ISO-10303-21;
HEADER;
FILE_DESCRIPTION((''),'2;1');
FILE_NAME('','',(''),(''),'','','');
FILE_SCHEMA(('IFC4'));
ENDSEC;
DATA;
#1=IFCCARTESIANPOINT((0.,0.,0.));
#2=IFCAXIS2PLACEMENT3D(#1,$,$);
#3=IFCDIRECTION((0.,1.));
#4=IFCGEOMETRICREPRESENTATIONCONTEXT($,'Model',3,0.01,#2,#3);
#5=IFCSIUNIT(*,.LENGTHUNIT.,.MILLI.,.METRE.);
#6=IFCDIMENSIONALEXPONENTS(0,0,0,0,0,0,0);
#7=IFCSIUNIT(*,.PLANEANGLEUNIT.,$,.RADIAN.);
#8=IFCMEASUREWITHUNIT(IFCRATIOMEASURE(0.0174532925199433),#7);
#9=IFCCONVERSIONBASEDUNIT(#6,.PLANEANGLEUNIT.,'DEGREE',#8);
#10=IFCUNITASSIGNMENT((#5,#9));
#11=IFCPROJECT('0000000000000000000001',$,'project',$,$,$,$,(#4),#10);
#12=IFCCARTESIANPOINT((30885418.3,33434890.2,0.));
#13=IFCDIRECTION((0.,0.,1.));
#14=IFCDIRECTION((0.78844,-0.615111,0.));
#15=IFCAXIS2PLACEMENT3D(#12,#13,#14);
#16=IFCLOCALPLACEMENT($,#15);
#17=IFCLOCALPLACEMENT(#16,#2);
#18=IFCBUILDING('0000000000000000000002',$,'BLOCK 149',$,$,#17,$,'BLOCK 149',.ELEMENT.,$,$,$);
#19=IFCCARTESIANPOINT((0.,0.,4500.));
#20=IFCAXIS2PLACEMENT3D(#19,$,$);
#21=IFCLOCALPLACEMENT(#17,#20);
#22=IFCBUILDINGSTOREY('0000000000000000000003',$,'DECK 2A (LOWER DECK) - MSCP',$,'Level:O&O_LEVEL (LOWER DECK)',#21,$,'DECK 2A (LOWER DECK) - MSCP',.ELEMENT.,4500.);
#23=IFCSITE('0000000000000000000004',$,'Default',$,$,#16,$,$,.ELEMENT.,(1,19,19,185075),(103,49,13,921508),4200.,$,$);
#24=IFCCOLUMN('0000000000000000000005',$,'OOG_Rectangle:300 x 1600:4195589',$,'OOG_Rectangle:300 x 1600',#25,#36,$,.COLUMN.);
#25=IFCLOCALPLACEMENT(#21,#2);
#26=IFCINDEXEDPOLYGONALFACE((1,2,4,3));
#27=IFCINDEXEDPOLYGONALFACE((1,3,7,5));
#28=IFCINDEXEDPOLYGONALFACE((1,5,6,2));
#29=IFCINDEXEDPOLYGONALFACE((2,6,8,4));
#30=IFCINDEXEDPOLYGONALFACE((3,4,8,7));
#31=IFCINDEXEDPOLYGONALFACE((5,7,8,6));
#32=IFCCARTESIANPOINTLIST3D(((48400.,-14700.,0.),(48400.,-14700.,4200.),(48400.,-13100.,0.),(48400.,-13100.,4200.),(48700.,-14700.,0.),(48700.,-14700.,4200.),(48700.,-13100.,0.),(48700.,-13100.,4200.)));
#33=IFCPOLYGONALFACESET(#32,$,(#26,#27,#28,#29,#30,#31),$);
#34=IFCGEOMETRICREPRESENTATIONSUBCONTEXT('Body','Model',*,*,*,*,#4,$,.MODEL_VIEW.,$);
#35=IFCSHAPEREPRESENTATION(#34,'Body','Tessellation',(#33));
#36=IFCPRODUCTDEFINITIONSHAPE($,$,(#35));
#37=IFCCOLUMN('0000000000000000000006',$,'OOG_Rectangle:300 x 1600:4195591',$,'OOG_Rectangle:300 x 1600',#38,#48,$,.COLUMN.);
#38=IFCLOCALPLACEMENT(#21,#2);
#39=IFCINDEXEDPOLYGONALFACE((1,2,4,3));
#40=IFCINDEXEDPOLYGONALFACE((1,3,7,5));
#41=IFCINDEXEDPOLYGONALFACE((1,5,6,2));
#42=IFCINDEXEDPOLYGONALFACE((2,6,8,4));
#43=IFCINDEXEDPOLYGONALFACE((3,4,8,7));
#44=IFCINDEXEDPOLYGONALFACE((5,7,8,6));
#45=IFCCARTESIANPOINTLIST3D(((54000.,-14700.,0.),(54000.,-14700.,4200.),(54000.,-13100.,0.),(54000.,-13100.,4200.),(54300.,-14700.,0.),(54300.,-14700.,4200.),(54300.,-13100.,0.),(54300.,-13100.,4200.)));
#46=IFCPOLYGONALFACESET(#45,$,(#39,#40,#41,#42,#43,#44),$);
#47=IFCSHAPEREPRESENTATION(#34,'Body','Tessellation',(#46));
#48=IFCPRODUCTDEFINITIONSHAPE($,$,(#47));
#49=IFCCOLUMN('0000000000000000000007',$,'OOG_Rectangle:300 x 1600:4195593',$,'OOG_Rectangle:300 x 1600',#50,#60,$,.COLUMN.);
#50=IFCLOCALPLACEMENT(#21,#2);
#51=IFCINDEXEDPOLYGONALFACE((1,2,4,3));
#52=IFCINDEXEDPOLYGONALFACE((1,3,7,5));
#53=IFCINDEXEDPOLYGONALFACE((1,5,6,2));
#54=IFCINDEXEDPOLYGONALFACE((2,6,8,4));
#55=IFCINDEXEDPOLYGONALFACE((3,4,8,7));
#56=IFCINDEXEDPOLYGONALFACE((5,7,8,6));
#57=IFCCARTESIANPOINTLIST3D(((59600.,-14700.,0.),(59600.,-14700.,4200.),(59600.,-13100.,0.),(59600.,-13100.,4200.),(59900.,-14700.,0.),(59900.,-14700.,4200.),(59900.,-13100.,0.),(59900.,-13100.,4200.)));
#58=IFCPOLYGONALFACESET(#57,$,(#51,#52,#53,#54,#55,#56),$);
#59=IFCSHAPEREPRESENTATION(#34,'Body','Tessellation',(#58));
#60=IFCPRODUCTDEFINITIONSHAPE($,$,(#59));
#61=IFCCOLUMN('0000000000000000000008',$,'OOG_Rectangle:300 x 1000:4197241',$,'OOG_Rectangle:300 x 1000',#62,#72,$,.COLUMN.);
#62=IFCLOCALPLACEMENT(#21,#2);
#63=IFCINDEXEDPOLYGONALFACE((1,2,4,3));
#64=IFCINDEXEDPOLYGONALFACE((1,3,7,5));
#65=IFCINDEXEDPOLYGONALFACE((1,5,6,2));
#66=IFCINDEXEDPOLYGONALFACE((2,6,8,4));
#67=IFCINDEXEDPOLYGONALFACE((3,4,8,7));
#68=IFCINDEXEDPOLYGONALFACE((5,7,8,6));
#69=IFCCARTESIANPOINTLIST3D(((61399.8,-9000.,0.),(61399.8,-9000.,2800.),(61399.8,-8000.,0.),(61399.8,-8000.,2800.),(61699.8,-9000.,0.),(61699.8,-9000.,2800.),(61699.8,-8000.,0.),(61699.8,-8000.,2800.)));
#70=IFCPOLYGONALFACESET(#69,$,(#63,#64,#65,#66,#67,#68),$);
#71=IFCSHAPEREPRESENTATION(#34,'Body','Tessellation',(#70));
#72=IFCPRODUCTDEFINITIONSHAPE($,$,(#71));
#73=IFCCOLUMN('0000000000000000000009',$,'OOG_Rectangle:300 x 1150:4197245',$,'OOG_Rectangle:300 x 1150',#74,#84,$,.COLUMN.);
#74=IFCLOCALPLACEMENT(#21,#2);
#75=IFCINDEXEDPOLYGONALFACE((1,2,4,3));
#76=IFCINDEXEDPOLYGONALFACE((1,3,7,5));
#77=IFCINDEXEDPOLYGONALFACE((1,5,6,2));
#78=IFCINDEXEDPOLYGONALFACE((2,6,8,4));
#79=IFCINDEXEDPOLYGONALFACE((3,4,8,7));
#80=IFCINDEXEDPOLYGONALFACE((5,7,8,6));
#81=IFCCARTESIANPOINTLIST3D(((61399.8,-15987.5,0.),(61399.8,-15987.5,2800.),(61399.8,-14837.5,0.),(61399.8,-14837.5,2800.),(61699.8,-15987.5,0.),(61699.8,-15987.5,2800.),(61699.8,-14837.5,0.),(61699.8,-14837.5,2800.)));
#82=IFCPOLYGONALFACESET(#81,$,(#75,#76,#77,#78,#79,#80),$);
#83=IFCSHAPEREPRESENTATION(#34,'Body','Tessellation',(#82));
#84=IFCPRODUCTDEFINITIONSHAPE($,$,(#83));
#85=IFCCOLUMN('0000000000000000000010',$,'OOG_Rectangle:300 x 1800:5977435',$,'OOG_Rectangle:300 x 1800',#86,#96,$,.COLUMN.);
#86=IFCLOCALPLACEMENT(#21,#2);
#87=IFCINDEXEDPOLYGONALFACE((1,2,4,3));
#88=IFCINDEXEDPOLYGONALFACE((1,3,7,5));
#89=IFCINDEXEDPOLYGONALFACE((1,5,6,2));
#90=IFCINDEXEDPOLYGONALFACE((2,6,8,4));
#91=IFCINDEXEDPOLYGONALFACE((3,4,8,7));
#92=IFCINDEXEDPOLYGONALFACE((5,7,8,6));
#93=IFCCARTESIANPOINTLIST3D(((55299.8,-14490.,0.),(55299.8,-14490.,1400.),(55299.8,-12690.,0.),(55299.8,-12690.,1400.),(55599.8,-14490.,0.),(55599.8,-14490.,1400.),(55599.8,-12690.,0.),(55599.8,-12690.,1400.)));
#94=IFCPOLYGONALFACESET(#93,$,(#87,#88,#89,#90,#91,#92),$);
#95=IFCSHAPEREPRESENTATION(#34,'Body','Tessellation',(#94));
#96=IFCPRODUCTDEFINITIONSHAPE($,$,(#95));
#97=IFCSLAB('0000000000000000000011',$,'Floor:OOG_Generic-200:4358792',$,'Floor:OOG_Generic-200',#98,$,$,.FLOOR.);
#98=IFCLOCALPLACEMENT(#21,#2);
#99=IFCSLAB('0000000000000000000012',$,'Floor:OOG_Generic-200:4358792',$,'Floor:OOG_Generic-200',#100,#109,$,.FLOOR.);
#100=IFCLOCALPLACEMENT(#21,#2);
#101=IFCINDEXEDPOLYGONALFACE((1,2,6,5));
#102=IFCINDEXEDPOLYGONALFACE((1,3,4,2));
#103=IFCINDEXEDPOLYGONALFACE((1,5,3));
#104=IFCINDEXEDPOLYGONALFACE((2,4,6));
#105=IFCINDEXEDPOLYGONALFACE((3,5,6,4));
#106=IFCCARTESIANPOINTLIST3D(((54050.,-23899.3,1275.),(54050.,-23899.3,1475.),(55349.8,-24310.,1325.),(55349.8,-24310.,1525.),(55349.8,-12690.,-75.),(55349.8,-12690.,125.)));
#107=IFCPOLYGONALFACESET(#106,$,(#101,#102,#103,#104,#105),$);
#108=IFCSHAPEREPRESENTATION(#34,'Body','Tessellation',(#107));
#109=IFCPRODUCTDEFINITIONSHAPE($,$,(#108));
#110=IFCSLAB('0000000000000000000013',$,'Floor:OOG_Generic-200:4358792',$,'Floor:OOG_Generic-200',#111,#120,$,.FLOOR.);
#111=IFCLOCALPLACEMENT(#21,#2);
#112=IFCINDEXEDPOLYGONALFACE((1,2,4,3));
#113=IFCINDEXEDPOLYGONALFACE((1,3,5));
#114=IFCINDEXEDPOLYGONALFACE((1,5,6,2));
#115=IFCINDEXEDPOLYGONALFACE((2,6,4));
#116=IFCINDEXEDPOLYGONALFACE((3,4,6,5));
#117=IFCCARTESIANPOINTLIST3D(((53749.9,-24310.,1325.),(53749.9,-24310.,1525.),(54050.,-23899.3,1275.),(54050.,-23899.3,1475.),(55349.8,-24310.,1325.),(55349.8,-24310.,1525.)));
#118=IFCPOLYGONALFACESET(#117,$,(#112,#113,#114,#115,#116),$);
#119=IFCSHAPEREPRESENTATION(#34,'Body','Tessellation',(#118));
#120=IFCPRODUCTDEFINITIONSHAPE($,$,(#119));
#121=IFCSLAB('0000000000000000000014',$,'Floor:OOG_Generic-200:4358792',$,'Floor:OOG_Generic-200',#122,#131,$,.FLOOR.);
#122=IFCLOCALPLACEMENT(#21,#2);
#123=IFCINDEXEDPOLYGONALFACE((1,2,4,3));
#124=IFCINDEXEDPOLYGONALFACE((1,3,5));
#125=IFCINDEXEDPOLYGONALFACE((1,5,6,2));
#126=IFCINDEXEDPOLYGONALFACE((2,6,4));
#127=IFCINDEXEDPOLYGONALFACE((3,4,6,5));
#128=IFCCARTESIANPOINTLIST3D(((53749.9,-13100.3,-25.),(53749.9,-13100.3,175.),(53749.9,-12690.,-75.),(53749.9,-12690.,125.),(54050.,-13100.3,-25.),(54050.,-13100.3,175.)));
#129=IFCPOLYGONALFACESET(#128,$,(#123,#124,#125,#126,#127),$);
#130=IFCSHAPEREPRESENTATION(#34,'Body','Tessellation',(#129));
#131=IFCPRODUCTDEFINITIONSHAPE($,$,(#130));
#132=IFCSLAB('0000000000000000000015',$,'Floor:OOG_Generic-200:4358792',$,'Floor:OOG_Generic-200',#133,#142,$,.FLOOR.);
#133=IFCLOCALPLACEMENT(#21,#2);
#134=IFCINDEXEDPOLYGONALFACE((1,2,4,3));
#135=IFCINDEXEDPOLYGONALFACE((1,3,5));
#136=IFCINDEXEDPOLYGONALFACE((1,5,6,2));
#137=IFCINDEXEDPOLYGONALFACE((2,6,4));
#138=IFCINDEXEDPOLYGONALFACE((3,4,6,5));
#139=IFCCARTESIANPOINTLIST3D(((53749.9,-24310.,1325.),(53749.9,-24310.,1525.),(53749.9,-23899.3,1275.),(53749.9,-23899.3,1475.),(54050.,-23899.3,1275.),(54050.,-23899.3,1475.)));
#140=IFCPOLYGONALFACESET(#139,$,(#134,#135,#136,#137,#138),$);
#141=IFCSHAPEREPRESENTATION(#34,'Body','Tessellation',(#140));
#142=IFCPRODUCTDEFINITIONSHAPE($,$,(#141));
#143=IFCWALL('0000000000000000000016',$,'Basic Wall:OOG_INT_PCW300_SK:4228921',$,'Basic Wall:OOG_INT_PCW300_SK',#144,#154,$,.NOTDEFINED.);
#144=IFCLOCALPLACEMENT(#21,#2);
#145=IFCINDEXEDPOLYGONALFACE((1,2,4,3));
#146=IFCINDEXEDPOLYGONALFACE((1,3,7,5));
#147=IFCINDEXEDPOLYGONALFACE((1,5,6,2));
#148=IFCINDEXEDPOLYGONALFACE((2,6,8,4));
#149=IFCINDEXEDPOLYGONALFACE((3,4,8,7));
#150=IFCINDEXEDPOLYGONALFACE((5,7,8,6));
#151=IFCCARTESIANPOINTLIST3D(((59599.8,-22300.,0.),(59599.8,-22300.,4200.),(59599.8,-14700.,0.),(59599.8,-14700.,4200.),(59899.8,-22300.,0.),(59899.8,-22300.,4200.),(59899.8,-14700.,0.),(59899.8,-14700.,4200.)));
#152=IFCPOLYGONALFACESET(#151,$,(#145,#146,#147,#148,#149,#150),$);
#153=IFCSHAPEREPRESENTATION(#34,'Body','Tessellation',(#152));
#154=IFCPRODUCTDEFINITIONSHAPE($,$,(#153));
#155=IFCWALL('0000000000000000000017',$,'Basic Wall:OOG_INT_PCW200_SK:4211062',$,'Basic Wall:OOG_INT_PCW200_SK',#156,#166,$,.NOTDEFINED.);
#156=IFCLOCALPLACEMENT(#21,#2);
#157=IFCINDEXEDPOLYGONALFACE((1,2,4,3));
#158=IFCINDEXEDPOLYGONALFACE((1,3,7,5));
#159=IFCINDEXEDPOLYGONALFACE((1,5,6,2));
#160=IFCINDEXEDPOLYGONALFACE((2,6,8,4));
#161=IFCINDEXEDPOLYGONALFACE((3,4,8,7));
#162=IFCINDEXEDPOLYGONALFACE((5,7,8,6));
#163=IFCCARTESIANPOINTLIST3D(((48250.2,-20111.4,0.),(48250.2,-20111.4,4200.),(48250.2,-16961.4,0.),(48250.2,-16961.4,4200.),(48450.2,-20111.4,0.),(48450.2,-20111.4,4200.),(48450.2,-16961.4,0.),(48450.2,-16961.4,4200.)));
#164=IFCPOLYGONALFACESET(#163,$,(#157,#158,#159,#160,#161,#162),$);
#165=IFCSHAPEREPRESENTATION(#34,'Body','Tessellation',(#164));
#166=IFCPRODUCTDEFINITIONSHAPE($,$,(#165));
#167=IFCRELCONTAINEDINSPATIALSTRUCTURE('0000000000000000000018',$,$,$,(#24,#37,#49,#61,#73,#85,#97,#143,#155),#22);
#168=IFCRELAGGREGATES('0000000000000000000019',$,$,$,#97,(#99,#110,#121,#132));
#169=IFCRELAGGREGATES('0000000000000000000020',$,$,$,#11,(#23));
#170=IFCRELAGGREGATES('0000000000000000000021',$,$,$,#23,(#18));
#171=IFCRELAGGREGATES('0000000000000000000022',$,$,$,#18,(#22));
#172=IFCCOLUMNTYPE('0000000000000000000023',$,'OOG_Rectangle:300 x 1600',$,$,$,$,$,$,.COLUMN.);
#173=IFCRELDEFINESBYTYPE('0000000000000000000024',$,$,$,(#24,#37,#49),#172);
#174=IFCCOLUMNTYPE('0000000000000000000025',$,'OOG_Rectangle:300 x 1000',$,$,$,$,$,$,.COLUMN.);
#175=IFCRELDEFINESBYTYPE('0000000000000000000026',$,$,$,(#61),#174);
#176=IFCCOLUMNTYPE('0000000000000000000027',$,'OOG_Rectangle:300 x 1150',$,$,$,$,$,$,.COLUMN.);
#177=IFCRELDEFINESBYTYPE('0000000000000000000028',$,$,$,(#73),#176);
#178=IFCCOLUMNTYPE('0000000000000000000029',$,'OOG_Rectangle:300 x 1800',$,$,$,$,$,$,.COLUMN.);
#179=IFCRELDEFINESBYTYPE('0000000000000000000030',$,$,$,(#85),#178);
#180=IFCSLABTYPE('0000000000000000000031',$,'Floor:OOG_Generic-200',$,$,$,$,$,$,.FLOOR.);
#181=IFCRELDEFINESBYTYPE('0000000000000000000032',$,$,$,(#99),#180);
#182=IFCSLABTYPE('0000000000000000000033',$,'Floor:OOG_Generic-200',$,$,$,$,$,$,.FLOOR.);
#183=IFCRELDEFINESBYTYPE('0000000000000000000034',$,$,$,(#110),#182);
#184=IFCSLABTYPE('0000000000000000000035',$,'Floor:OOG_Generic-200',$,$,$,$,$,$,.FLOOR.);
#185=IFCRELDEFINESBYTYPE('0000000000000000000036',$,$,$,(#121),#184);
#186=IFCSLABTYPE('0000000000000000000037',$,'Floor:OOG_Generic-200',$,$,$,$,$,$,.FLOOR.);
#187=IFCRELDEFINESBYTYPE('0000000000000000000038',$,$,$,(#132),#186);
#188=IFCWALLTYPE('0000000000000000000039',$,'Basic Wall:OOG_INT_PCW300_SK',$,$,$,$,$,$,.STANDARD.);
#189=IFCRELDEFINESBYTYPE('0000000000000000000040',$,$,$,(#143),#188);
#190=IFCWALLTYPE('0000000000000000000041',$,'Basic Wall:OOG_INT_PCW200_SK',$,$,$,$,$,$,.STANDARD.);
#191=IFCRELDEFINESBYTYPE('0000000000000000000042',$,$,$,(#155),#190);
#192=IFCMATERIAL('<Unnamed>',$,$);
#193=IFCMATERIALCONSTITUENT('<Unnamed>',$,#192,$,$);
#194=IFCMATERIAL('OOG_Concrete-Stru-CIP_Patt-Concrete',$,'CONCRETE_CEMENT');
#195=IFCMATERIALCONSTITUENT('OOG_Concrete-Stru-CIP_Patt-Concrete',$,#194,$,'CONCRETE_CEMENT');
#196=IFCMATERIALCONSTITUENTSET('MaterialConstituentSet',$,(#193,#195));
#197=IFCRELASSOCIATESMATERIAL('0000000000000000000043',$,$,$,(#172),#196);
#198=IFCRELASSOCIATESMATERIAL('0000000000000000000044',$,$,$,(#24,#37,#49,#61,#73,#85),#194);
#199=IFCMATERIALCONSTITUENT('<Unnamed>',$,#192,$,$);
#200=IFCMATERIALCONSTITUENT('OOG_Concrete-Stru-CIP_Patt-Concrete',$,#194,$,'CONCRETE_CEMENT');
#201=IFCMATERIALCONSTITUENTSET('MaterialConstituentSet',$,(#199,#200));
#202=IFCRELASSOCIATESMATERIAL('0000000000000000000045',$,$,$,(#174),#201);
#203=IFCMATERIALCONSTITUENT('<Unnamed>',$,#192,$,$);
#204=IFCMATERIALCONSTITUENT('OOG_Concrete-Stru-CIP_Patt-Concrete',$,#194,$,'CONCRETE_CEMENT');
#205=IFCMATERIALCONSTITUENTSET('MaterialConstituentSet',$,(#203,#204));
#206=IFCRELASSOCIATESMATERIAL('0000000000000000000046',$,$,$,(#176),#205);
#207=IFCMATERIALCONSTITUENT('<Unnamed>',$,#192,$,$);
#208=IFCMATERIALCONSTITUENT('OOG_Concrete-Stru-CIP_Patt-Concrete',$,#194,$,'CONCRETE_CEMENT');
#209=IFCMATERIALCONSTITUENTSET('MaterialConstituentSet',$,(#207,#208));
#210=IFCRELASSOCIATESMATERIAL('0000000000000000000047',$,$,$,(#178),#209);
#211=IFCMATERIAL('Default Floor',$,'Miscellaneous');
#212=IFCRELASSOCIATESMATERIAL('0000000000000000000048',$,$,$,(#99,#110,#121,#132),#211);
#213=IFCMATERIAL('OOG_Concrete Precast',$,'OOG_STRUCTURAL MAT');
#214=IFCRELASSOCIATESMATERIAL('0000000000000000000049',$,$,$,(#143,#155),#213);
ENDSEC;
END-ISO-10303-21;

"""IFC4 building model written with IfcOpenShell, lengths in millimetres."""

from ifc_helpers import new_model, entity, si_unit, converted_unit, direction, frame, origin, place, context, subcontext, project, spatial, indexed_curve, outline, extrude, source, transform, mapped, material, constituent, constituent_set, type_object, type_shapes, element, aggregate, save


model = new_model("IFC4")

# Units and contexts
model_context = context("Model", 3, precision=0.01, world=origin(), true_north=direction((0.0, 1.0)))
body_context = subcontext(model_context, "Body", "Model", "MODEL_VIEW")
ifc_project = project(units=[si_unit("LENGTHUNIT", "METRE", prefix="MILLI"), converted_unit("PLANEANGLEUNIT", "DEGREE", entity("IfcRatioMeasure", 0.0174532925199433), si_unit("PLANEANGLEUNIT", "RADIAN"), dimensions=[0, 0, 0, 0, 0, 0, 0])], contexts=[model_context])

# Site, building, storey
site_placement = place(None, frame((30885418.3, 33434890.2, 0.0), z_axis=(0.0, 0.0, 1.0), x_axis=(0.78844, -0.615111, 0.0)))
site = spatial("IfcSite", under=ifc_project, at=site_placement, Name="Default", CompositionType="ELEMENT", RefLatitude=(1, 19, 19, 185075), RefLongitude=(103, 49, 13, 921508), RefElevation=4200.0)
building_placement = place(site_placement, origin())
building = spatial("IfcBuilding", under=site, at=building_placement, Name="BLOCK 149", LongName="BLOCK 149", CompositionType="ELEMENT")
storey_placement = place(building_placement, frame((0.0, 0.0, 4500.0)))
storey = spatial("IfcBuildingStorey", under=building, at=storey_placement, Name="DECK 2A (LOWER DECK) - MSCP", ObjectType="Level:O&O_LEVEL (LOWER DECK)", LongName="DECK 2A (LOWER DECK) - MSCP", CompositionType="ELEMENT", Elevation=4500.0)

# Columns
ifc_material_1 = material(Name="OOG_Concrete-Stru-CIP_Patt-Concrete", Category="CONCRETE_CEMENT")
ifc_material_2 = material(Name="<Unnamed>")
ifc_constituent_1 = constituent(ifc_material_2, Name="<Unnamed>")
ifc_constituent_2 = constituent(ifc_material_1, Name="OOG_Concrete-Stru-CIP_Patt-Concrete", Category="CONCRETE_CEMENT")
ifc_constituent_set_1 = constituent_set(constituents=[ifc_constituent_1, ifc_constituent_2], Name="MaterialConstituentSet")
column_type_1 = type_object("IfcColumnType", Name="OOG_Rectangle:300 x 1600", PredefinedType="COLUMN", material=ifc_constituent_set_1)
shared_shape_1 = source(origin(), body_context, "Body", "SweptSolid", [
    extrude(outline(indexed_curve([(-800.0, -150.0), (800.0, -150.0), (800.0, 150.0), (-800.0, 150.0), (-800.0, -150.0)], self_intersect=False)), frame((0.0, 0.0, 4500.0), z_axis=(0.0, 0.0, 1.0), x_axis=(0.0, -1.0, 0.0)), (0.0, 0.0, 1.0), 4200.0),
])
type_shapes(column_type_1, [shared_shape_1])
for number, where, name in (
    (1, (48550.0, -13900.0, -4500.0), "OOG_Rectangle:300 x 1600:4195589"),
    (2, (54150.0, -13900.0, -4500.0), "OOG_Rectangle:300 x 1600:4195591"),
    (3, (59750.0, -13900.0, -4500.0), "OOG_Rectangle:300 x 1600:4195593"),
):
    element("IfcColumn", number, at=place(storey_placement, frame(where)), inside=storey, type_object=column_type_1, material=ifc_material_1, Name=name, ObjectType="OOG_Rectangle:300 x 1600", PredefinedType="COLUMN", context=body_context, shape_type="MappedRepresentation", body=[
        mapped(shared_shape_1, transform((0.0, 0.0, 0.0), scale=1.0)),
    ])
ifc_constituent_3 = constituent(ifc_material_2, Name="<Unnamed>")
ifc_constituent_4 = constituent(ifc_material_1, Name="OOG_Concrete-Stru-CIP_Patt-Concrete", Category="CONCRETE_CEMENT")
ifc_constituent_set_2 = constituent_set(constituents=[ifc_constituent_3, ifc_constituent_4], Name="MaterialConstituentSet")
column_type_2 = type_object("IfcColumnType", Name="OOG_Rectangle:300 x 1000", PredefinedType="COLUMN", material=ifc_constituent_set_2)
shared_shape_2 = source(origin(), body_context, "Body", "SweptSolid", [
    extrude(outline(indexed_curve([(-500.0, -150.0), (500.0, -150.0), (500.0, 150.0), (-500.0, 150.0), (-500.0, -150.0)], self_intersect=False)), frame((0.0, 0.0, 4500.0), z_axis=(0.0, 0.0, 1.0), x_axis=(0.0, -1.0, 0.0)), (0.0, 0.0, 1.0), 2800.0),
])
type_shapes(column_type_2, [shared_shape_2])
column_1_placement = place(storey_placement, frame((61549.8, -8500.0, -4500.0)))
element("IfcColumn", 4, at=column_1_placement, inside=storey, type_object=column_type_2, material=ifc_material_1, Name="OOG_Rectangle:300 x 1000:4197241", ObjectType="OOG_Rectangle:300 x 1000", PredefinedType="COLUMN", context=body_context, shape_type="MappedRepresentation", body=[
    mapped(shared_shape_2, transform((0.0, 0.0, 0.0), scale=1.0)),
])
ifc_constituent_5 = constituent(ifc_material_2, Name="<Unnamed>")
ifc_constituent_6 = constituent(ifc_material_1, Name="OOG_Concrete-Stru-CIP_Patt-Concrete", Category="CONCRETE_CEMENT")
ifc_constituent_set_3 = constituent_set(constituents=[ifc_constituent_5, ifc_constituent_6], Name="MaterialConstituentSet")
column_type_3 = type_object("IfcColumnType", Name="OOG_Rectangle:300 x 1150", PredefinedType="COLUMN", material=ifc_constituent_set_3)
shared_shape_3 = source(origin(), body_context, "Body", "SweptSolid", [
    extrude(outline(indexed_curve([(-575.0, -150.0), (575.0, -150.0), (575.0, 150.0), (-575.0, 150.0), (-575.0, -150.0)], self_intersect=False)), frame((0.0, 0.0, 4500.0), z_axis=(0.0, 0.0, 1.0), x_axis=(0.0, -1.0, 0.0)), (0.0, 0.0, 1.0), 2800.0),
])
type_shapes(column_type_3, [shared_shape_3])
column_2_placement = place(storey_placement, frame((61549.8, -15412.5, -4500.0), z_axis=(0.0, 0.0, 1.0), x_axis=(-1.0, 0.0, 0.0)))
element("IfcColumn", 5, at=column_2_placement, inside=storey, type_object=column_type_3, material=ifc_material_1, Name="OOG_Rectangle:300 x 1150:4197245", ObjectType="OOG_Rectangle:300 x 1150", PredefinedType="COLUMN", context=body_context, shape_type="MappedRepresentation", body=[
    mapped(shared_shape_3, transform((0.0, 0.0, 0.0), scale=1.0)),
])
ifc_constituent_7 = constituent(ifc_material_2, Name="<Unnamed>")
ifc_constituent_8 = constituent(ifc_material_1, Name="OOG_Concrete-Stru-CIP_Patt-Concrete", Category="CONCRETE_CEMENT")
ifc_constituent_set_4 = constituent_set(constituents=[ifc_constituent_7, ifc_constituent_8], Name="MaterialConstituentSet")
column_type_4 = type_object("IfcColumnType", Name="OOG_Rectangle:300 x 1800", PredefinedType="COLUMN", material=ifc_constituent_set_4)
shared_shape_4 = source(origin(), body_context, "Body", "SweptSolid", [
    extrude(outline(indexed_curve([(-900.0, -150.0), (900.0, -150.0), (900.0, 150.0), (-900.0, 150.0), (-900.0, -150.0)], self_intersect=False)), frame((0.0, 0.0, 4500.0), z_axis=(0.0, 0.0, 1.0), x_axis=(0.0, -1.0, 0.0)), (0.0, 0.0, 1.0), 1400.0),
])
type_shapes(column_type_4, [shared_shape_4])
column_3_placement = place(storey_placement, frame((55449.8, -13590.0, -4500.0)))
element("IfcColumn", 6, at=column_3_placement, inside=storey, type_object=column_type_4, material=ifc_material_1, Name="OOG_Rectangle:300 x 1800:5977435", ObjectType="OOG_Rectangle:300 x 1800", PredefinedType="COLUMN", context=body_context, shape_type="MappedRepresentation", body=[
    mapped(shared_shape_4, transform((0.0, 0.0, 0.0), scale=1.0)),
])

# Slabs
slab_1_placement = place(storey_placement, frame((53749.9, -24310.0, -75.0)))
slab_1 = element("IfcSlab", 7, at=slab_1_placement, inside=storey, Name="Floor:OOG_Generic-200:4358792", ObjectType="Floor:OOG_Generic-200", PredefinedType="FLOOR")
ifc_material_3 = material(Name="Default Floor", Category="Miscellaneous")
slab_type_1 = type_object("IfcSlabType", Name="Floor:OOG_Generic-200", PredefinedType="FLOOR")
slab_2_placement = place(slab_1_placement, origin())
slab_2 = element("IfcSlab", 8, at=slab_2_placement, type_object=slab_type_1, material=ifc_material_3, Name="Floor:OOG_Generic-200:4358792", ObjectType="Floor:OOG_Generic-200", PredefinedType="FLOOR", context=body_context, shape_type="SweptSolid", body=[
    extrude(outline(indexed_curve([(649.9, -5852.0), (649.9, 5852.0), (-649.9, -5438.2), (649.9, -5852.0)], self_intersect=False)), frame((950.0, 5810.0, 899.7), z_axis=(-0.000392, 0.119617, 0.99282), x_axis=(1.0, 0.000047, 0.000389)), (-0.000389, 0.119617, -0.99282), 200.0),
])
slab_type_2 = type_object("IfcSlabType", Name="Floor:OOG_Generic-200", PredefinedType="FLOOR")
slab_3_placement = place(slab_1_placement, origin())
slab_3 = element("IfcSlab", 9, at=slab_3_placement, type_object=slab_type_2, material=ifc_material_3, Name="Floor:OOG_Generic-200:4358792", ObjectType="Floor:OOG_Generic-200", PredefinedType="FLOOR", context=body_context, shape_type="SweptSolid", body=[
    extrude(outline(indexed_curve([(799.9, 0.0), (-499.8, 413.8), (-799.9, 0.0), (799.9, 0.0)], self_intersect=False)), frame((800.0, 0.0, 1600.0), z_axis=(0.0, 0.120838, 0.992672), x_axis=(1.0, 0.0, 0.0)), (0.0, 0.120838, -0.992672), 200.0),
])
slab_type_3 = type_object("IfcSlabType", Name="Floor:OOG_Generic-200", PredefinedType="FLOOR")
slab_4_placement = place(slab_1_placement, origin())
slab_4 = element("IfcSlab", 10, at=slab_4_placement, type_object=slab_type_3, material=ifc_material_3, Name="Floor:OOG_Generic-200:4358792", ObjectType="Floor:OOG_Generic-200", PredefinedType="FLOOR", context=body_context, shape_type="SweptSolid", body=[
    extrude(outline(indexed_curve([(-150.1, 206.7), (-150.1, -206.7), (150.1, -206.7), (-150.1, 206.7)], self_intersect=False)), frame((150.1, 11414.9, 225.0), z_axis=(0.0, 0.120972, 0.992656), x_axis=(1.0, 0.0, 0.0)), (0.0, 0.120972, -0.992656), 200.0),
])
slab_type_4 = type_object("IfcSlabType", Name="Floor:OOG_Generic-200", PredefinedType="FLOOR")
slab_5_placement = place(slab_1_placement, origin())
slab_5 = element("IfcSlab", 11, at=slab_5_placement, type_object=slab_type_4, material=ifc_material_3, Name="Floor:OOG_Generic-200:4358792", ObjectType="Floor:OOG_Generic-200", PredefinedType="FLOOR", context=body_context, shape_type="SweptSolid", body=[
    extrude(outline(indexed_curve([(150.1, 206.9), (-150.1, 206.9), (-150.1, -206.9), (150.1, 206.9)], self_intersect=False)), frame((150.1, 205.4, 1575.0), z_axis=(0.0, 0.120838, 0.992672), x_axis=(1.0, 0.0, 0.0)), (0.0, 0.120838, -0.992672), 200.0),
])
aggregate(slab_1, [slab_2, slab_3, slab_4, slab_5])

# Walls
ifc_material_4 = material(Name="OOG_Concrete Precast", Category="OOG_STRUCTURAL MAT")
wall_type_1 = type_object("IfcWallType", Name="Basic Wall:OOG_INT_PCW300_SK", PredefinedType="STANDARD")
wall_1_placement = place(storey_placement, frame((59749.8, -14700.0, 0.0), z_axis=(0.0, 0.0, 1.0), x_axis=(0.000001, -1.0, 0.0)))
element("IfcWall", 12, at=wall_1_placement, inside=storey, type_object=wall_type_1, material=ifc_material_4, Name="Basic Wall:OOG_INT_PCW300_SK:4228921", ObjectType="Basic Wall:OOG_INT_PCW300_SK", PredefinedType="NOTDEFINED", context=body_context, shape_type="SweptSolid", body=[
    extrude(outline(indexed_curve([(7600.0, 150.0), (0.0, 150.0), (0.0, -150.0), (7600.0, -150.0), (7600.0, 150.0)], self_intersect=False)), origin(), (0.0, 0.0, 1.0), 4200.0),
])
wall_type_2 = type_object("IfcWallType", Name="Basic Wall:OOG_INT_PCW200_SK", PredefinedType="STANDARD")
wall_2_placement = place(storey_placement, frame((48350.2, -16961.4, 0.0), z_axis=(0.0, 0.0, 1.0), x_axis=(0.0, -1.0, 0.0)))
element("IfcWall", 13, at=wall_2_placement, inside=storey, type_object=wall_type_2, material=ifc_material_4, Name="Basic Wall:OOG_INT_PCW200_SK:4211062", ObjectType="Basic Wall:OOG_INT_PCW200_SK", PredefinedType="NOTDEFINED", context=body_context, shape_type="SweptSolid", body=[
    extrude(outline(indexed_curve([(3150.0, 100.0), (0.0, 100.0), (0.0, -100.0), (3150.0, -100.0), (3150.0, 100.0)], self_intersect=False)), origin(), (0.0, 0.0, 1.0), 4200.0),
])

save(model, "model.ifc")
